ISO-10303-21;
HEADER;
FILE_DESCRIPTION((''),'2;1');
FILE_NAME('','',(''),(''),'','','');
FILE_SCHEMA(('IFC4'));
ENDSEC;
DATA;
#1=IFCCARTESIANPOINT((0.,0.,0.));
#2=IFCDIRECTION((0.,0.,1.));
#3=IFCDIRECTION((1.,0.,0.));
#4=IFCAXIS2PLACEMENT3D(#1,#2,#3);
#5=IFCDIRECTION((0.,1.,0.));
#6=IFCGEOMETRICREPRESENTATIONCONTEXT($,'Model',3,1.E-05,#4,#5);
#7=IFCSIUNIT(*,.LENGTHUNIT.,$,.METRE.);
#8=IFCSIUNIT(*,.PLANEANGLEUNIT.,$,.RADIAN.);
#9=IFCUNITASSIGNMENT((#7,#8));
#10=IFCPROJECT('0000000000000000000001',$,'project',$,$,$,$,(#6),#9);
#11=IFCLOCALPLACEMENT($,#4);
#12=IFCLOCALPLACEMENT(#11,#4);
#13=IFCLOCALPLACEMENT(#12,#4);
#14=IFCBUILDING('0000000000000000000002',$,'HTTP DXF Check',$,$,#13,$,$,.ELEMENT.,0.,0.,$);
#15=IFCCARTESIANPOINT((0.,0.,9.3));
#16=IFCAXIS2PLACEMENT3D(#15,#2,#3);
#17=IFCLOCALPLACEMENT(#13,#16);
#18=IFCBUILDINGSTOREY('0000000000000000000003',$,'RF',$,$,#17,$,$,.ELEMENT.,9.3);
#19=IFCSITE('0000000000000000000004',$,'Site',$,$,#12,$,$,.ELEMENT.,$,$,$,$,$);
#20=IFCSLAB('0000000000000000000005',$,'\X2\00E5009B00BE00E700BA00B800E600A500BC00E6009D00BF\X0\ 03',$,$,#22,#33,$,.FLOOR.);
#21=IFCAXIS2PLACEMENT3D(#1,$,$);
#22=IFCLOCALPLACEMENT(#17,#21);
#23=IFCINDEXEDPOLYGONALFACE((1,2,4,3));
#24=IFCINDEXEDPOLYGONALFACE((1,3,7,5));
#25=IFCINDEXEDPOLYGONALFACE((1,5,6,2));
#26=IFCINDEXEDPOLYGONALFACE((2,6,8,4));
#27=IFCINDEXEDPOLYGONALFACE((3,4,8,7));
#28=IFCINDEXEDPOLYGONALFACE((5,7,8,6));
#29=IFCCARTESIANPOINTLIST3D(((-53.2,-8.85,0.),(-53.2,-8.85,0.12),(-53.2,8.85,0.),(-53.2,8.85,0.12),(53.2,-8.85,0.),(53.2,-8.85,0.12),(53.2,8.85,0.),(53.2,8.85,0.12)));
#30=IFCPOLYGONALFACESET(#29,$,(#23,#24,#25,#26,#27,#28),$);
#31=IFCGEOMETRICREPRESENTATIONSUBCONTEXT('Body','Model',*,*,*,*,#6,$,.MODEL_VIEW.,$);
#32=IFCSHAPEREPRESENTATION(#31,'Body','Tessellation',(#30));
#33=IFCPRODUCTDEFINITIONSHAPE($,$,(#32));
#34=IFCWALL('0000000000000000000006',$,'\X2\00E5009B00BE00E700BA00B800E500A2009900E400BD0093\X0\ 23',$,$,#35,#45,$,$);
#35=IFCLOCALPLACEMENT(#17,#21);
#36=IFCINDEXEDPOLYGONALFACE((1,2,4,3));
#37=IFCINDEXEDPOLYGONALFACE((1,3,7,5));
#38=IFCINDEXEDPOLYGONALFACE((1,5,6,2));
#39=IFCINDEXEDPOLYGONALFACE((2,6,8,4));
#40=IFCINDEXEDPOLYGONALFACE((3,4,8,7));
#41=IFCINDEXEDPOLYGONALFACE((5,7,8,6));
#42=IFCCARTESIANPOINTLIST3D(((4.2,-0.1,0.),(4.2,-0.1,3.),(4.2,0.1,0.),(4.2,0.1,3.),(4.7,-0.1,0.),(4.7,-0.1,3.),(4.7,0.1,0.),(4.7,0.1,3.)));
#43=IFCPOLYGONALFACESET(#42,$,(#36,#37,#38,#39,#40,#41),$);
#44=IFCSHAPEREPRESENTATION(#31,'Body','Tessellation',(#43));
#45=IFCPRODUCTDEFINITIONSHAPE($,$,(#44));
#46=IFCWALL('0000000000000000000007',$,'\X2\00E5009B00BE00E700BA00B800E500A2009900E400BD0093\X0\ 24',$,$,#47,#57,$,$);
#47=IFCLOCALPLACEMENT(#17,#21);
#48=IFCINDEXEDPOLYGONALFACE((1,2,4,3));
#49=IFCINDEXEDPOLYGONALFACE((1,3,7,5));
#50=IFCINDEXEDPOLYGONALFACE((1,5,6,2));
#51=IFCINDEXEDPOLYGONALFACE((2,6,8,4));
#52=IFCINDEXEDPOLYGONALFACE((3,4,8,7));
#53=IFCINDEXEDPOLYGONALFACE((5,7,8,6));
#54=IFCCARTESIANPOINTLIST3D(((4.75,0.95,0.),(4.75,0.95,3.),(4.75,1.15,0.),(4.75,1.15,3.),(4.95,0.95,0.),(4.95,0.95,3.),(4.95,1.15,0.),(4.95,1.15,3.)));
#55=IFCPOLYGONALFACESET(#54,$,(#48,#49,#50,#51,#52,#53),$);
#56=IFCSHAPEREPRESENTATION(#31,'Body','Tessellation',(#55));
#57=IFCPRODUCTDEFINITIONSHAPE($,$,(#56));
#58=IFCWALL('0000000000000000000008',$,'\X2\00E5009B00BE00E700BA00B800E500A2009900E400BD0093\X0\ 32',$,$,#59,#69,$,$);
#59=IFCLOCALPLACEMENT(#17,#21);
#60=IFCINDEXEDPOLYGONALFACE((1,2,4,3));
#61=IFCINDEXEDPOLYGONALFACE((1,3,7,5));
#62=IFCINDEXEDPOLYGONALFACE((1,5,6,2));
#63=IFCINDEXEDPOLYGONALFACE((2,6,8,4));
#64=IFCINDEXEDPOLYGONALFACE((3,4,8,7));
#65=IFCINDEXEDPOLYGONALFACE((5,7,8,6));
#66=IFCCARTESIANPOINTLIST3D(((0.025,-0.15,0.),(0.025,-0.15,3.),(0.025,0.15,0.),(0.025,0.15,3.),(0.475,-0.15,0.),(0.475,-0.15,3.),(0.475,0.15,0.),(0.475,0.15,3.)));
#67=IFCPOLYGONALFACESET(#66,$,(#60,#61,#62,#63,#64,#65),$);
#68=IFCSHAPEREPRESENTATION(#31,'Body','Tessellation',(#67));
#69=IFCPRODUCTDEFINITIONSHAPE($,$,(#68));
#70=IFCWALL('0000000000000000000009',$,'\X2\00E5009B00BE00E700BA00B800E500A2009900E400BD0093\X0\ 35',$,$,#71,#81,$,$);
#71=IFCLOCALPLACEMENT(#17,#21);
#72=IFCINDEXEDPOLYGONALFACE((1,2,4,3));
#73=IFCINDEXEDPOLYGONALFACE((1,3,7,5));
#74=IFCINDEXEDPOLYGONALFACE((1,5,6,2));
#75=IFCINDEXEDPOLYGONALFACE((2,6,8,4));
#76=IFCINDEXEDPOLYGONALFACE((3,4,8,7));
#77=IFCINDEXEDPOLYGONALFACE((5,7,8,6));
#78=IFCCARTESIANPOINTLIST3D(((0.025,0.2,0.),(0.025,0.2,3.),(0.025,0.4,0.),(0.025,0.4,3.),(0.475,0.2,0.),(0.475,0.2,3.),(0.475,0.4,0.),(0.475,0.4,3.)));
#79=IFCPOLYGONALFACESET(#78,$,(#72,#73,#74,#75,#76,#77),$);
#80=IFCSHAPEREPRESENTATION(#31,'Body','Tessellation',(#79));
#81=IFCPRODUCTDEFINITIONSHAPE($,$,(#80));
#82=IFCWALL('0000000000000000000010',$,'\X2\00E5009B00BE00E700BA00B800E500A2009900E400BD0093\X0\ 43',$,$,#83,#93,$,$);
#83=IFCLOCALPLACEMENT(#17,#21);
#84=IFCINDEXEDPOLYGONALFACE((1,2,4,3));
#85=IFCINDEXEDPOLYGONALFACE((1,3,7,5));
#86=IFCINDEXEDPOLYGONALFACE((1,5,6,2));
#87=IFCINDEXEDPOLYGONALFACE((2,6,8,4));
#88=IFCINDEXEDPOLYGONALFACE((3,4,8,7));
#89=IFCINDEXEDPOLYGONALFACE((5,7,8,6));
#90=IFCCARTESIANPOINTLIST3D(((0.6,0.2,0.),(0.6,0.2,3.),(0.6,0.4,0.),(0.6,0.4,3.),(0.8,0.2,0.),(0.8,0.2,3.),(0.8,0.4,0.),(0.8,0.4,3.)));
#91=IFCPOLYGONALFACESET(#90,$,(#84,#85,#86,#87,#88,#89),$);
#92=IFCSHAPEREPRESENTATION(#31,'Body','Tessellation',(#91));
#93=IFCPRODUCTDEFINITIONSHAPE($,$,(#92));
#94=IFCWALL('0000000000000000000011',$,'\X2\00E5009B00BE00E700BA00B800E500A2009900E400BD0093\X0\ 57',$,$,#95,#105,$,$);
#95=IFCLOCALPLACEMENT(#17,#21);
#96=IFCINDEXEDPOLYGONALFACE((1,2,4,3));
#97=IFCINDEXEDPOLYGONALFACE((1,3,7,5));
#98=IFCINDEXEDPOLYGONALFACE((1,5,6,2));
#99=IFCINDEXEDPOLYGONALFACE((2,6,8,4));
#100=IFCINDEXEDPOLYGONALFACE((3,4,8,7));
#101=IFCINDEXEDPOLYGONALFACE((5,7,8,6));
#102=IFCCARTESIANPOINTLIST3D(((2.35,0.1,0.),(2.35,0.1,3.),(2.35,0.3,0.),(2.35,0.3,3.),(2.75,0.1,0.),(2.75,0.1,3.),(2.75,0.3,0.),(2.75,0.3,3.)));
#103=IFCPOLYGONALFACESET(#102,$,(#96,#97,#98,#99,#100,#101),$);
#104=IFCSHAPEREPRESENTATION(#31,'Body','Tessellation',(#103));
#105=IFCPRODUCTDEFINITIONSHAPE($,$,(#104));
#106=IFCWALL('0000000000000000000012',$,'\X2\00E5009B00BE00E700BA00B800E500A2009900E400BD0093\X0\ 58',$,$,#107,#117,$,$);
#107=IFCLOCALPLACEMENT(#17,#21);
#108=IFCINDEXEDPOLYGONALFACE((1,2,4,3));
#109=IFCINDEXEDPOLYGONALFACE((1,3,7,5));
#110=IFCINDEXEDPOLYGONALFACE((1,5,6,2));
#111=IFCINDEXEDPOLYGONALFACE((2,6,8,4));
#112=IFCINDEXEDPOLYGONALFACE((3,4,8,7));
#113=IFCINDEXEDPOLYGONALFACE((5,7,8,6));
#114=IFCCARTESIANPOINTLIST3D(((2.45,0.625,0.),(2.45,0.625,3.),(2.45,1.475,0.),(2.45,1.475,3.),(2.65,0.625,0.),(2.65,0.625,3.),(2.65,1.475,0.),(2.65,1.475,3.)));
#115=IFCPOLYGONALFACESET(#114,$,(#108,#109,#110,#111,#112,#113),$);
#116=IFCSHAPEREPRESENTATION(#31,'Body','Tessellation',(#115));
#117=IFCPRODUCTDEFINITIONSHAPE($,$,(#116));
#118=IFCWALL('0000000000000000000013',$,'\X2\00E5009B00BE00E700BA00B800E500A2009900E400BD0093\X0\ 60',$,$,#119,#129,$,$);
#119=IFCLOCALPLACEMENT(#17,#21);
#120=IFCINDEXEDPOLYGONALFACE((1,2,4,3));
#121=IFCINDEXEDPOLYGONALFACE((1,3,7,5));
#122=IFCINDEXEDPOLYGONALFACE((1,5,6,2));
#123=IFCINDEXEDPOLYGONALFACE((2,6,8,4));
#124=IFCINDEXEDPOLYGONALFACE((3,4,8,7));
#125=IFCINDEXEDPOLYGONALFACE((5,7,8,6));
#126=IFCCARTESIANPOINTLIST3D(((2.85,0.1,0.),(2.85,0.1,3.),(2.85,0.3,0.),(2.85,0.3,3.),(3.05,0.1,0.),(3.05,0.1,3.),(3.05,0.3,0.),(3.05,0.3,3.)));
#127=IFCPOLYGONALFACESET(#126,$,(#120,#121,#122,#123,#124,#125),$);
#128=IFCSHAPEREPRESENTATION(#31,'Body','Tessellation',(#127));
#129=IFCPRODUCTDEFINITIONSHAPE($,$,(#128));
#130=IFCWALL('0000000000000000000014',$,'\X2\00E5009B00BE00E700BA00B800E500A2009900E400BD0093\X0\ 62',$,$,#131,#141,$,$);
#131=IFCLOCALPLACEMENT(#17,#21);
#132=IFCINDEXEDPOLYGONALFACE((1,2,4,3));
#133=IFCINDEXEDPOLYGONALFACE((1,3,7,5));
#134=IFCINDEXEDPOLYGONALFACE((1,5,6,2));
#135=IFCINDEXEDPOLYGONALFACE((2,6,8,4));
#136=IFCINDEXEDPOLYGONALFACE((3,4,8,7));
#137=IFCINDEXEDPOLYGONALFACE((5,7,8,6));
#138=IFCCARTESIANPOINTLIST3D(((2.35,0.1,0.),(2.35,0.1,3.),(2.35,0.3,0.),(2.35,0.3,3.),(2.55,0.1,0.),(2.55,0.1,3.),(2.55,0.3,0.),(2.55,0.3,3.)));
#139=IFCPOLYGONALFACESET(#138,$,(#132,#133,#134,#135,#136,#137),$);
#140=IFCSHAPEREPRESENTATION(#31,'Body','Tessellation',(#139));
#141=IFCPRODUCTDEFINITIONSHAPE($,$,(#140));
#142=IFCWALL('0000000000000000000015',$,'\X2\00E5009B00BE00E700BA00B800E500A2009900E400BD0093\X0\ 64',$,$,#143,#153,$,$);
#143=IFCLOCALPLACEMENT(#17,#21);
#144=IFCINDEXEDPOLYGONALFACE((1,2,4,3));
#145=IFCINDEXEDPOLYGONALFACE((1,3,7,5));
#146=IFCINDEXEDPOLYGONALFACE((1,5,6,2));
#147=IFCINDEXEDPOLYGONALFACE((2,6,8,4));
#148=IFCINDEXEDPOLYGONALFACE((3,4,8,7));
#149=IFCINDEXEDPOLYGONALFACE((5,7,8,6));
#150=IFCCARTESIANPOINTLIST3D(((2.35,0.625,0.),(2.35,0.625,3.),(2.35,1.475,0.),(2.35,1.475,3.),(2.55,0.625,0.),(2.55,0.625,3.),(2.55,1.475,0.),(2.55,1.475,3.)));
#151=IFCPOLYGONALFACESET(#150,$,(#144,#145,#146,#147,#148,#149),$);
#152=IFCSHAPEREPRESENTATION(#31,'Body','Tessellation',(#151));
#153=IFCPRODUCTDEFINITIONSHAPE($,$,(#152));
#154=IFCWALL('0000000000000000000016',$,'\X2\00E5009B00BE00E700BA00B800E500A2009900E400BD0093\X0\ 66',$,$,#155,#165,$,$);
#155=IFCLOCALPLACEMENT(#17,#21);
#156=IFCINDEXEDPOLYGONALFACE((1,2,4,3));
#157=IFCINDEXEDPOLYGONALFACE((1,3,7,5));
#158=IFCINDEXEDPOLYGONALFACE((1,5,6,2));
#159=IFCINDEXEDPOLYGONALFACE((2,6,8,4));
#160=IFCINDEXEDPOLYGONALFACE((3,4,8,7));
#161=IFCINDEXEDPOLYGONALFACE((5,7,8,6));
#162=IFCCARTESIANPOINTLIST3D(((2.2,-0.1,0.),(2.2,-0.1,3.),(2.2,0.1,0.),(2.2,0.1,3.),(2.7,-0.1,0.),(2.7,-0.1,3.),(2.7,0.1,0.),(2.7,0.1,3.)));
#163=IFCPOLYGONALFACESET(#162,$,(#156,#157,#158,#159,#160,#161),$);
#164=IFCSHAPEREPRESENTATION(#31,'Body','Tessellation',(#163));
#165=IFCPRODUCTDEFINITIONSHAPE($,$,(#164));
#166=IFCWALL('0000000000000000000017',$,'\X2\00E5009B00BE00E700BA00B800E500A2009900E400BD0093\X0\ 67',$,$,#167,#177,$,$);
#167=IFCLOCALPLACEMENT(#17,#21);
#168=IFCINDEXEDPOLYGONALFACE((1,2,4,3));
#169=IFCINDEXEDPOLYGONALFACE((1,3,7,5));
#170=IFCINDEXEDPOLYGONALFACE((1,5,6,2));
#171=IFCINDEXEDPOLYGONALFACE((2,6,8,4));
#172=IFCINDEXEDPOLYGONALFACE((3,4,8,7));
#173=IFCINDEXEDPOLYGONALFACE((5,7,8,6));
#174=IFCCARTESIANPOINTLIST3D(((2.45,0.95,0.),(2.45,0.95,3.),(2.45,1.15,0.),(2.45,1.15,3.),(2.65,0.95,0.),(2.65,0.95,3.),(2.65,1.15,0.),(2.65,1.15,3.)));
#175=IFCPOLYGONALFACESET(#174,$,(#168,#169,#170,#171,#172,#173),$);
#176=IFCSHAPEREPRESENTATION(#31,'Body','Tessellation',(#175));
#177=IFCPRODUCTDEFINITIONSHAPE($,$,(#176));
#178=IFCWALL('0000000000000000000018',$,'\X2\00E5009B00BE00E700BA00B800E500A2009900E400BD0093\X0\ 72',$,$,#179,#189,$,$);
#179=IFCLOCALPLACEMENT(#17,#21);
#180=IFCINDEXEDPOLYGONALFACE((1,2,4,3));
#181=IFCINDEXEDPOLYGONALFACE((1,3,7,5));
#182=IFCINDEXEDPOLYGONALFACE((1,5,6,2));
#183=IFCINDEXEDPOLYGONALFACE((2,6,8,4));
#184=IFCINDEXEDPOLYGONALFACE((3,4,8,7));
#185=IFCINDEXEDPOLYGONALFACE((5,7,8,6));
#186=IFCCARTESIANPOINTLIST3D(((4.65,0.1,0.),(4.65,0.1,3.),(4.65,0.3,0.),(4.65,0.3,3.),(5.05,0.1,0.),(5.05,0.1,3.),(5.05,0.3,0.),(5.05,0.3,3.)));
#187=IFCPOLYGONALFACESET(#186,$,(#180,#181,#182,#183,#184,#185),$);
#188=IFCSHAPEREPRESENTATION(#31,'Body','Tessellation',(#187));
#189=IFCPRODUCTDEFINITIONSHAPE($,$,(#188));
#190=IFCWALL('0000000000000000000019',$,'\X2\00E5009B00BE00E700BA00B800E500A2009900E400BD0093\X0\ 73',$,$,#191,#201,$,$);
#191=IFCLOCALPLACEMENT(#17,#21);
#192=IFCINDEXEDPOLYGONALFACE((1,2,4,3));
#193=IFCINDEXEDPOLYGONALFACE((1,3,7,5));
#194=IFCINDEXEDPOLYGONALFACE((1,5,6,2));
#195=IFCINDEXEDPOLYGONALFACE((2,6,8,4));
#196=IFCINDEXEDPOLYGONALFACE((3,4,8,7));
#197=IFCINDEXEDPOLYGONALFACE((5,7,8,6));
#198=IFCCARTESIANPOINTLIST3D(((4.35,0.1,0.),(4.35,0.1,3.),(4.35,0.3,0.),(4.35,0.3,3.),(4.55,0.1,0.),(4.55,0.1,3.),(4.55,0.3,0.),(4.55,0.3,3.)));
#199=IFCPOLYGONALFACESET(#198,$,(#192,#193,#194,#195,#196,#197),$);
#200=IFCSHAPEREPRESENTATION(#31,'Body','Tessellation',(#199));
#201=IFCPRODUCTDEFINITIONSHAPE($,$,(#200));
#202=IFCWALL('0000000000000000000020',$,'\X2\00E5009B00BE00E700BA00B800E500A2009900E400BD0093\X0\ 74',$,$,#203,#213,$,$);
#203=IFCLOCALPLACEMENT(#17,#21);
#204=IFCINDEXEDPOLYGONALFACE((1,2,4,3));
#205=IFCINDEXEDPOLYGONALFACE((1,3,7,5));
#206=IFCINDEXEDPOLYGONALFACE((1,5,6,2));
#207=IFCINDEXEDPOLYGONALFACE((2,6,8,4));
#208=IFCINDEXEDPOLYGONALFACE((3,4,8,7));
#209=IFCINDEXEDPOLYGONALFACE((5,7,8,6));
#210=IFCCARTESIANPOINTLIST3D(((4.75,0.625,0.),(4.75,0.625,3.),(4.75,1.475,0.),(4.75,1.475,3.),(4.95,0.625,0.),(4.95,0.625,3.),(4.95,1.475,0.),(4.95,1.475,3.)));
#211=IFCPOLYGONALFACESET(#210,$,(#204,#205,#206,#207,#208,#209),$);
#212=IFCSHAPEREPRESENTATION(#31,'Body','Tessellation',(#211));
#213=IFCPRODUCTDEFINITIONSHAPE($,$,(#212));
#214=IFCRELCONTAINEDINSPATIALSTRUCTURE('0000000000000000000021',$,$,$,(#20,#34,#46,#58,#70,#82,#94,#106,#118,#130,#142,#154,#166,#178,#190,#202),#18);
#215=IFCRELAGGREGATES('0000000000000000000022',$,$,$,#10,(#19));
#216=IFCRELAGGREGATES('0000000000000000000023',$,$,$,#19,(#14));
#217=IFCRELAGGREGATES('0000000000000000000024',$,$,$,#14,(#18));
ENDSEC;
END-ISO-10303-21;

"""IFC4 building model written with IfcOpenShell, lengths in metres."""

from ifc_helpers import new_model, si_unit, direction, frame, frame_2d, origin_with_axes, place, context, subcontext, project, spatial, rectangle, extrude, element, save


model = new_model("IFC4")

# Units and contexts
model_context = context("Model", 3, precision=1e-05, world=origin_with_axes(), true_north=direction((0.0, 1.0, 0.0)))
body_context = subcontext(model_context, "Body", "Model", "MODEL_VIEW")
ifc_project = project(units=[si_unit("LENGTHUNIT", "METRE"), si_unit("PLANEANGLEUNIT", "RADIAN")], contexts=[model_context])

# Site, building, storey
placement = place(None, origin_with_axes())
site_placement = place(placement, origin_with_axes())
site = spatial("IfcSite", under=ifc_project, at=site_placement, Name="Site", CompositionType="ELEMENT")
building_placement = place(site_placement, origin_with_axes())
building = spatial("IfcBuilding", under=site, at=building_placement, Name="HTTP DXF Check", CompositionType="ELEMENT", ElevationOfRefHeight=0.0, ElevationOfTerrain=0.0)
storey_placement = place(building_placement, frame((0.0, 0.0, 9.3), z_axis=(0.0, 0.0, 1.0), x_axis=(1.0, 0.0, 0.0)))
storey = spatial("IfcBuildingStorey", under=building, at=storey_placement, Name="RF", CompositionType="ELEMENT", Elevation=9.3)

# Slab
slab_placement = place(storey_placement, origin_with_axes())
element("IfcSlab", 1, at=slab_placement, inside=storey, Name="å\u009b¾çº¸æ¥¼æ\u009d¿ 03", PredefinedType="FLOOR", context=body_context, shape_type="SweptSolid", body=[
    extrude(rectangle(XDim=106.4, YDim=17.7, at=frame_2d((0.0, 0.0), x_axis=(1.0, 0.0, 0.0))), frame((0.0, 0.0, 0.0), z_axis=(0.0, 0.0, 1.0)), (0.0, 0.0, 1.0), 0.12),
])

# Walls
wall_1_placement = place(storey_placement, frame((4.45, 0.0, 0.0), z_axis=(0.0, 0.0, 1.0), x_axis=(1.0, 0.0, 0.0)))
element("IfcWall", 2, at=wall_1_placement, inside=storey, Name="å\u009b¾çº¸å¢\u0099ä½\u0093 23", context=body_context, shape_type="SweptSolid", body=[
    extrude(rectangle(XDim=0.5, YDim=0.2, at=frame_2d((0.0, 0.0), x_axis=(1.0, 0.0, 0.0))), frame((0.0, 0.0, 0.0), z_axis=(0.0, 0.0, 1.0)), (0.0, 0.0, 1.0), 3.0),
])
wall_2_placement = place(storey_placement, frame((4.85, 1.05, 0.0), z_axis=(0.0, 0.0, 1.0), x_axis=(1.0, 0.0, 0.0)))
element("IfcWall", 3, at=wall_2_placement, inside=storey, Name="å\u009b¾çº¸å¢\u0099ä½\u0093 24", context=body_context, shape_type="SweptSolid", body=[
    extrude(rectangle(XDim=0.2, YDim=0.2, at=frame_2d((0.0, 0.0), x_axis=(1.0, 0.0, 0.0))), frame((0.0, 0.0, 0.0), z_axis=(0.0, 0.0, 1.0)), (0.0, 0.0, 1.0), 3.0),
])
wall_3_placement = place(storey_placement, frame((0.25, 0.0, 0.0), z_axis=(0.0, 0.0, 1.0), x_axis=(1.0, 0.0, 0.0)))
element("IfcWall", 4, at=wall_3_placement, inside=storey, Name="å\u009b¾çº¸å¢\u0099ä½\u0093 32", context=body_context, shape_type="SweptSolid", body=[
    extrude(rectangle(XDim=0.45, YDim=0.3, at=frame_2d((0.0, 0.0), x_axis=(1.0, 0.0, 0.0))), frame((0.0, 0.0, 0.0), z_axis=(0.0, 0.0, 1.0)), (0.0, 0.0, 1.0), 3.0),
])
wall_4_placement = place(storey_placement, frame((0.25, 0.3, 0.0), z_axis=(0.0, 0.0, 1.0), x_axis=(1.0, 0.0, 0.0)))
element("IfcWall", 5, at=wall_4_placement, inside=storey, Name="å\u009b¾çº¸å¢\u0099ä½\u0093 35", context=body_context, shape_type="SweptSolid", body=[
    extrude(rectangle(XDim=0.45, YDim=0.2, at=frame_2d((0.0, 0.0), x_axis=(1.0, 0.0, 0.0))), frame((0.0, 0.0, 0.0), z_axis=(0.0, 0.0, 1.0)), (0.0, 0.0, 1.0), 3.0),
])
wall_5_placement = place(storey_placement, frame((0.7, 0.3, 0.0), z_axis=(0.0, 0.0, 1.0), x_axis=(0.0, -1.0, 0.0)))
element("IfcWall", 6, at=wall_5_placement, inside=storey, Name="å\u009b¾çº¸å¢\u0099ä½\u0093 43", context=body_context, shape_type="SweptSolid", body=[
    extrude(rectangle(XDim=0.2, YDim=0.2, at=frame_2d((0.0, 0.0), x_axis=(1.0, 0.0, 0.0))), frame((0.0, 0.0, 0.0), z_axis=(0.0, 0.0, 1.0)), (0.0, 0.0, 1.0), 3.0),
])
wall_6_placement = place(storey_placement, frame((2.55, 0.2, 0.0), z_axis=(0.0, 0.0, 1.0), x_axis=(1.0, 0.0, 0.0)))
element("IfcWall", 7, at=wall_6_placement, inside=storey, Name="å\u009b¾çº¸å¢\u0099ä½\u0093 57", context=body_context, shape_type="SweptSolid", body=[
    extrude(rectangle(XDim=0.4, YDim=0.2, at=frame_2d((0.0, 0.0), x_axis=(1.0, 0.0, 0.0))), frame((0.0, 0.0, 0.0), z_axis=(0.0, 0.0, 1.0)), (0.0, 0.0, 1.0), 3.0),
])
wall_7_placement = place(storey_placement, frame((2.55, 1.05, 0.0), z_axis=(0.0, 0.0, 1.0), x_axis=(0.0, -1.0, 0.0)))
element("IfcWall", 8, at=wall_7_placement, inside=storey, Name="å\u009b¾çº¸å¢\u0099ä½\u0093 58", context=body_context, shape_type="SweptSolid", body=[
    extrude(rectangle(XDim=0.85, YDim=0.2, at=frame_2d((0.0, 0.0), x_axis=(1.0, 0.0, 0.0))), frame((0.0, 0.0, 0.0), z_axis=(0.0, 0.0, 1.0)), (0.0, 0.0, 1.0), 3.0),
])
for number, where, z_axis, x_axis, name in (
    (9, (2.95, 0.2, 0.0), (0.0, 0.0, 1.0), (0.0, -1.0, 0.0), "å\u009b¾çº¸å¢\u0099ä½\u0093 60"),
    (10, (2.45, 0.2, 0.0), (0.0, 0.0, 1.0), (0.0, -1.0, 0.0), "å\u009b¾çº¸å¢\u0099ä½\u0093 62"),
):
    element("IfcWall", number, at=place(storey_placement, frame(where, z_axis=z_axis, x_axis=x_axis)), inside=storey, Name=name, context=body_context, shape_type="SweptSolid", body=[
        extrude(rectangle(XDim=0.2, YDim=0.2, at=frame_2d((0.0, 0.0), x_axis=(1.0, 0.0, 0.0))), frame((0.0, 0.0, 0.0), z_axis=(0.0, 0.0, 1.0)), (0.0, 0.0, 1.0), 3.0),
    ])
wall_8_placement = place(storey_placement, frame((2.45, 1.05, 0.0), z_axis=(0.0, 0.0, 1.0), x_axis=(0.0, -1.0, 0.0)))
element("IfcWall", 11, at=wall_8_placement, inside=storey, Name="å\u009b¾çº¸å¢\u0099ä½\u0093 64", context=body_context, shape_type="SweptSolid", body=[
    extrude(rectangle(XDim=0.85, YDim=0.2, at=frame_2d((0.0, 0.0), x_axis=(1.0, 0.0, 0.0))), frame((0.0, 0.0, 0.0), z_axis=(0.0, 0.0, 1.0)), (0.0, 0.0, 1.0), 3.0),
])
wall_9_placement = place(storey_placement, frame((2.45, 0.0, 0.0), z_axis=(0.0, 0.0, 1.0), x_axis=(1.0, 0.0, 0.0)))
element("IfcWall", 12, at=wall_9_placement, inside=storey, Name="å\u009b¾çº¸å¢\u0099ä½\u0093 66", context=body_context, shape_type="SweptSolid", body=[
    extrude(rectangle(XDim=0.5, YDim=0.2, at=frame_2d((0.0, 0.0), x_axis=(1.0, 0.0, 0.0))), frame((0.0, 0.0, 0.0), z_axis=(0.0, 0.0, 1.0)), (0.0, 0.0, 1.0), 3.0),
])
wall_10_placement = place(storey_placement, frame((2.55, 1.05, 0.0), z_axis=(0.0, 0.0, 1.0), x_axis=(-1.0, 0.0, 0.0)))
element("IfcWall", 13, at=wall_10_placement, inside=storey, Name="å\u009b¾çº¸å¢\u0099ä½\u0093 67", context=body_context, shape_type="SweptSolid", body=[
    extrude(rectangle(XDim=0.2, YDim=0.2, at=frame_2d((0.0, 0.0), x_axis=(1.0, 0.0, 0.0))), frame((0.0, 0.0, 0.0), z_axis=(0.0, 0.0, 1.0)), (0.0, 0.0, 1.0), 3.0),
])
wall_11_placement = place(storey_placement, frame((4.85, 0.2, 0.0), z_axis=(0.0, 0.0, 1.0), x_axis=(-1.0, 0.0, 0.0)))
element("IfcWall", 14, at=wall_11_placement, inside=storey, Name="å\u009b¾çº¸å¢\u0099ä½\u0093 72", context=body_context, shape_type="SweptSolid", body=[
    extrude(rectangle(XDim=0.4, YDim=0.2, at=frame_2d((0.0, 0.0), x_axis=(1.0, 0.0, 0.0))), frame((0.0, 0.0, 0.0), z_axis=(0.0, 0.0, 1.0)), (0.0, 0.0, 1.0), 3.0),
])
wall_12_placement = place(storey_placement, frame((4.45, 0.2, 0.0), z_axis=(0.0, 0.0, 1.0), x_axis=(0.0, -1.0, 0.0)))
element("IfcWall", 15, at=wall_12_placement, inside=storey, Name="å\u009b¾çº¸å¢\u0099ä½\u0093 73", context=body_context, shape_type="SweptSolid", body=[
    extrude(rectangle(XDim=0.2, YDim=0.2, at=frame_2d((0.0, 0.0), x_axis=(1.0, 0.0, 0.0))), frame((0.0, 0.0, 0.0), z_axis=(0.0, 0.0, 1.0)), (0.0, 0.0, 1.0), 3.0),
])
wall_13_placement = place(storey_placement, frame((4.85, 1.05, 0.0), z_axis=(0.0, 0.0, 1.0), x_axis=(0.0, -1.0, 0.0)))
element("IfcWall", 16, at=wall_13_placement, inside=storey, Name="å\u009b¾çº¸å¢\u0099ä½\u0093 74", context=body_context, shape_type="SweptSolid", body=[
    extrude(rectangle(XDim=0.85, YDim=0.2, at=frame_2d((0.0, 0.0), x_axis=(1.0, 0.0, 0.0))), frame((0.0, 0.0, 0.0), z_axis=(0.0, 0.0, 1.0)), (0.0, 0.0, 1.0), 3.0),
])

save(model, "model.ifc")
